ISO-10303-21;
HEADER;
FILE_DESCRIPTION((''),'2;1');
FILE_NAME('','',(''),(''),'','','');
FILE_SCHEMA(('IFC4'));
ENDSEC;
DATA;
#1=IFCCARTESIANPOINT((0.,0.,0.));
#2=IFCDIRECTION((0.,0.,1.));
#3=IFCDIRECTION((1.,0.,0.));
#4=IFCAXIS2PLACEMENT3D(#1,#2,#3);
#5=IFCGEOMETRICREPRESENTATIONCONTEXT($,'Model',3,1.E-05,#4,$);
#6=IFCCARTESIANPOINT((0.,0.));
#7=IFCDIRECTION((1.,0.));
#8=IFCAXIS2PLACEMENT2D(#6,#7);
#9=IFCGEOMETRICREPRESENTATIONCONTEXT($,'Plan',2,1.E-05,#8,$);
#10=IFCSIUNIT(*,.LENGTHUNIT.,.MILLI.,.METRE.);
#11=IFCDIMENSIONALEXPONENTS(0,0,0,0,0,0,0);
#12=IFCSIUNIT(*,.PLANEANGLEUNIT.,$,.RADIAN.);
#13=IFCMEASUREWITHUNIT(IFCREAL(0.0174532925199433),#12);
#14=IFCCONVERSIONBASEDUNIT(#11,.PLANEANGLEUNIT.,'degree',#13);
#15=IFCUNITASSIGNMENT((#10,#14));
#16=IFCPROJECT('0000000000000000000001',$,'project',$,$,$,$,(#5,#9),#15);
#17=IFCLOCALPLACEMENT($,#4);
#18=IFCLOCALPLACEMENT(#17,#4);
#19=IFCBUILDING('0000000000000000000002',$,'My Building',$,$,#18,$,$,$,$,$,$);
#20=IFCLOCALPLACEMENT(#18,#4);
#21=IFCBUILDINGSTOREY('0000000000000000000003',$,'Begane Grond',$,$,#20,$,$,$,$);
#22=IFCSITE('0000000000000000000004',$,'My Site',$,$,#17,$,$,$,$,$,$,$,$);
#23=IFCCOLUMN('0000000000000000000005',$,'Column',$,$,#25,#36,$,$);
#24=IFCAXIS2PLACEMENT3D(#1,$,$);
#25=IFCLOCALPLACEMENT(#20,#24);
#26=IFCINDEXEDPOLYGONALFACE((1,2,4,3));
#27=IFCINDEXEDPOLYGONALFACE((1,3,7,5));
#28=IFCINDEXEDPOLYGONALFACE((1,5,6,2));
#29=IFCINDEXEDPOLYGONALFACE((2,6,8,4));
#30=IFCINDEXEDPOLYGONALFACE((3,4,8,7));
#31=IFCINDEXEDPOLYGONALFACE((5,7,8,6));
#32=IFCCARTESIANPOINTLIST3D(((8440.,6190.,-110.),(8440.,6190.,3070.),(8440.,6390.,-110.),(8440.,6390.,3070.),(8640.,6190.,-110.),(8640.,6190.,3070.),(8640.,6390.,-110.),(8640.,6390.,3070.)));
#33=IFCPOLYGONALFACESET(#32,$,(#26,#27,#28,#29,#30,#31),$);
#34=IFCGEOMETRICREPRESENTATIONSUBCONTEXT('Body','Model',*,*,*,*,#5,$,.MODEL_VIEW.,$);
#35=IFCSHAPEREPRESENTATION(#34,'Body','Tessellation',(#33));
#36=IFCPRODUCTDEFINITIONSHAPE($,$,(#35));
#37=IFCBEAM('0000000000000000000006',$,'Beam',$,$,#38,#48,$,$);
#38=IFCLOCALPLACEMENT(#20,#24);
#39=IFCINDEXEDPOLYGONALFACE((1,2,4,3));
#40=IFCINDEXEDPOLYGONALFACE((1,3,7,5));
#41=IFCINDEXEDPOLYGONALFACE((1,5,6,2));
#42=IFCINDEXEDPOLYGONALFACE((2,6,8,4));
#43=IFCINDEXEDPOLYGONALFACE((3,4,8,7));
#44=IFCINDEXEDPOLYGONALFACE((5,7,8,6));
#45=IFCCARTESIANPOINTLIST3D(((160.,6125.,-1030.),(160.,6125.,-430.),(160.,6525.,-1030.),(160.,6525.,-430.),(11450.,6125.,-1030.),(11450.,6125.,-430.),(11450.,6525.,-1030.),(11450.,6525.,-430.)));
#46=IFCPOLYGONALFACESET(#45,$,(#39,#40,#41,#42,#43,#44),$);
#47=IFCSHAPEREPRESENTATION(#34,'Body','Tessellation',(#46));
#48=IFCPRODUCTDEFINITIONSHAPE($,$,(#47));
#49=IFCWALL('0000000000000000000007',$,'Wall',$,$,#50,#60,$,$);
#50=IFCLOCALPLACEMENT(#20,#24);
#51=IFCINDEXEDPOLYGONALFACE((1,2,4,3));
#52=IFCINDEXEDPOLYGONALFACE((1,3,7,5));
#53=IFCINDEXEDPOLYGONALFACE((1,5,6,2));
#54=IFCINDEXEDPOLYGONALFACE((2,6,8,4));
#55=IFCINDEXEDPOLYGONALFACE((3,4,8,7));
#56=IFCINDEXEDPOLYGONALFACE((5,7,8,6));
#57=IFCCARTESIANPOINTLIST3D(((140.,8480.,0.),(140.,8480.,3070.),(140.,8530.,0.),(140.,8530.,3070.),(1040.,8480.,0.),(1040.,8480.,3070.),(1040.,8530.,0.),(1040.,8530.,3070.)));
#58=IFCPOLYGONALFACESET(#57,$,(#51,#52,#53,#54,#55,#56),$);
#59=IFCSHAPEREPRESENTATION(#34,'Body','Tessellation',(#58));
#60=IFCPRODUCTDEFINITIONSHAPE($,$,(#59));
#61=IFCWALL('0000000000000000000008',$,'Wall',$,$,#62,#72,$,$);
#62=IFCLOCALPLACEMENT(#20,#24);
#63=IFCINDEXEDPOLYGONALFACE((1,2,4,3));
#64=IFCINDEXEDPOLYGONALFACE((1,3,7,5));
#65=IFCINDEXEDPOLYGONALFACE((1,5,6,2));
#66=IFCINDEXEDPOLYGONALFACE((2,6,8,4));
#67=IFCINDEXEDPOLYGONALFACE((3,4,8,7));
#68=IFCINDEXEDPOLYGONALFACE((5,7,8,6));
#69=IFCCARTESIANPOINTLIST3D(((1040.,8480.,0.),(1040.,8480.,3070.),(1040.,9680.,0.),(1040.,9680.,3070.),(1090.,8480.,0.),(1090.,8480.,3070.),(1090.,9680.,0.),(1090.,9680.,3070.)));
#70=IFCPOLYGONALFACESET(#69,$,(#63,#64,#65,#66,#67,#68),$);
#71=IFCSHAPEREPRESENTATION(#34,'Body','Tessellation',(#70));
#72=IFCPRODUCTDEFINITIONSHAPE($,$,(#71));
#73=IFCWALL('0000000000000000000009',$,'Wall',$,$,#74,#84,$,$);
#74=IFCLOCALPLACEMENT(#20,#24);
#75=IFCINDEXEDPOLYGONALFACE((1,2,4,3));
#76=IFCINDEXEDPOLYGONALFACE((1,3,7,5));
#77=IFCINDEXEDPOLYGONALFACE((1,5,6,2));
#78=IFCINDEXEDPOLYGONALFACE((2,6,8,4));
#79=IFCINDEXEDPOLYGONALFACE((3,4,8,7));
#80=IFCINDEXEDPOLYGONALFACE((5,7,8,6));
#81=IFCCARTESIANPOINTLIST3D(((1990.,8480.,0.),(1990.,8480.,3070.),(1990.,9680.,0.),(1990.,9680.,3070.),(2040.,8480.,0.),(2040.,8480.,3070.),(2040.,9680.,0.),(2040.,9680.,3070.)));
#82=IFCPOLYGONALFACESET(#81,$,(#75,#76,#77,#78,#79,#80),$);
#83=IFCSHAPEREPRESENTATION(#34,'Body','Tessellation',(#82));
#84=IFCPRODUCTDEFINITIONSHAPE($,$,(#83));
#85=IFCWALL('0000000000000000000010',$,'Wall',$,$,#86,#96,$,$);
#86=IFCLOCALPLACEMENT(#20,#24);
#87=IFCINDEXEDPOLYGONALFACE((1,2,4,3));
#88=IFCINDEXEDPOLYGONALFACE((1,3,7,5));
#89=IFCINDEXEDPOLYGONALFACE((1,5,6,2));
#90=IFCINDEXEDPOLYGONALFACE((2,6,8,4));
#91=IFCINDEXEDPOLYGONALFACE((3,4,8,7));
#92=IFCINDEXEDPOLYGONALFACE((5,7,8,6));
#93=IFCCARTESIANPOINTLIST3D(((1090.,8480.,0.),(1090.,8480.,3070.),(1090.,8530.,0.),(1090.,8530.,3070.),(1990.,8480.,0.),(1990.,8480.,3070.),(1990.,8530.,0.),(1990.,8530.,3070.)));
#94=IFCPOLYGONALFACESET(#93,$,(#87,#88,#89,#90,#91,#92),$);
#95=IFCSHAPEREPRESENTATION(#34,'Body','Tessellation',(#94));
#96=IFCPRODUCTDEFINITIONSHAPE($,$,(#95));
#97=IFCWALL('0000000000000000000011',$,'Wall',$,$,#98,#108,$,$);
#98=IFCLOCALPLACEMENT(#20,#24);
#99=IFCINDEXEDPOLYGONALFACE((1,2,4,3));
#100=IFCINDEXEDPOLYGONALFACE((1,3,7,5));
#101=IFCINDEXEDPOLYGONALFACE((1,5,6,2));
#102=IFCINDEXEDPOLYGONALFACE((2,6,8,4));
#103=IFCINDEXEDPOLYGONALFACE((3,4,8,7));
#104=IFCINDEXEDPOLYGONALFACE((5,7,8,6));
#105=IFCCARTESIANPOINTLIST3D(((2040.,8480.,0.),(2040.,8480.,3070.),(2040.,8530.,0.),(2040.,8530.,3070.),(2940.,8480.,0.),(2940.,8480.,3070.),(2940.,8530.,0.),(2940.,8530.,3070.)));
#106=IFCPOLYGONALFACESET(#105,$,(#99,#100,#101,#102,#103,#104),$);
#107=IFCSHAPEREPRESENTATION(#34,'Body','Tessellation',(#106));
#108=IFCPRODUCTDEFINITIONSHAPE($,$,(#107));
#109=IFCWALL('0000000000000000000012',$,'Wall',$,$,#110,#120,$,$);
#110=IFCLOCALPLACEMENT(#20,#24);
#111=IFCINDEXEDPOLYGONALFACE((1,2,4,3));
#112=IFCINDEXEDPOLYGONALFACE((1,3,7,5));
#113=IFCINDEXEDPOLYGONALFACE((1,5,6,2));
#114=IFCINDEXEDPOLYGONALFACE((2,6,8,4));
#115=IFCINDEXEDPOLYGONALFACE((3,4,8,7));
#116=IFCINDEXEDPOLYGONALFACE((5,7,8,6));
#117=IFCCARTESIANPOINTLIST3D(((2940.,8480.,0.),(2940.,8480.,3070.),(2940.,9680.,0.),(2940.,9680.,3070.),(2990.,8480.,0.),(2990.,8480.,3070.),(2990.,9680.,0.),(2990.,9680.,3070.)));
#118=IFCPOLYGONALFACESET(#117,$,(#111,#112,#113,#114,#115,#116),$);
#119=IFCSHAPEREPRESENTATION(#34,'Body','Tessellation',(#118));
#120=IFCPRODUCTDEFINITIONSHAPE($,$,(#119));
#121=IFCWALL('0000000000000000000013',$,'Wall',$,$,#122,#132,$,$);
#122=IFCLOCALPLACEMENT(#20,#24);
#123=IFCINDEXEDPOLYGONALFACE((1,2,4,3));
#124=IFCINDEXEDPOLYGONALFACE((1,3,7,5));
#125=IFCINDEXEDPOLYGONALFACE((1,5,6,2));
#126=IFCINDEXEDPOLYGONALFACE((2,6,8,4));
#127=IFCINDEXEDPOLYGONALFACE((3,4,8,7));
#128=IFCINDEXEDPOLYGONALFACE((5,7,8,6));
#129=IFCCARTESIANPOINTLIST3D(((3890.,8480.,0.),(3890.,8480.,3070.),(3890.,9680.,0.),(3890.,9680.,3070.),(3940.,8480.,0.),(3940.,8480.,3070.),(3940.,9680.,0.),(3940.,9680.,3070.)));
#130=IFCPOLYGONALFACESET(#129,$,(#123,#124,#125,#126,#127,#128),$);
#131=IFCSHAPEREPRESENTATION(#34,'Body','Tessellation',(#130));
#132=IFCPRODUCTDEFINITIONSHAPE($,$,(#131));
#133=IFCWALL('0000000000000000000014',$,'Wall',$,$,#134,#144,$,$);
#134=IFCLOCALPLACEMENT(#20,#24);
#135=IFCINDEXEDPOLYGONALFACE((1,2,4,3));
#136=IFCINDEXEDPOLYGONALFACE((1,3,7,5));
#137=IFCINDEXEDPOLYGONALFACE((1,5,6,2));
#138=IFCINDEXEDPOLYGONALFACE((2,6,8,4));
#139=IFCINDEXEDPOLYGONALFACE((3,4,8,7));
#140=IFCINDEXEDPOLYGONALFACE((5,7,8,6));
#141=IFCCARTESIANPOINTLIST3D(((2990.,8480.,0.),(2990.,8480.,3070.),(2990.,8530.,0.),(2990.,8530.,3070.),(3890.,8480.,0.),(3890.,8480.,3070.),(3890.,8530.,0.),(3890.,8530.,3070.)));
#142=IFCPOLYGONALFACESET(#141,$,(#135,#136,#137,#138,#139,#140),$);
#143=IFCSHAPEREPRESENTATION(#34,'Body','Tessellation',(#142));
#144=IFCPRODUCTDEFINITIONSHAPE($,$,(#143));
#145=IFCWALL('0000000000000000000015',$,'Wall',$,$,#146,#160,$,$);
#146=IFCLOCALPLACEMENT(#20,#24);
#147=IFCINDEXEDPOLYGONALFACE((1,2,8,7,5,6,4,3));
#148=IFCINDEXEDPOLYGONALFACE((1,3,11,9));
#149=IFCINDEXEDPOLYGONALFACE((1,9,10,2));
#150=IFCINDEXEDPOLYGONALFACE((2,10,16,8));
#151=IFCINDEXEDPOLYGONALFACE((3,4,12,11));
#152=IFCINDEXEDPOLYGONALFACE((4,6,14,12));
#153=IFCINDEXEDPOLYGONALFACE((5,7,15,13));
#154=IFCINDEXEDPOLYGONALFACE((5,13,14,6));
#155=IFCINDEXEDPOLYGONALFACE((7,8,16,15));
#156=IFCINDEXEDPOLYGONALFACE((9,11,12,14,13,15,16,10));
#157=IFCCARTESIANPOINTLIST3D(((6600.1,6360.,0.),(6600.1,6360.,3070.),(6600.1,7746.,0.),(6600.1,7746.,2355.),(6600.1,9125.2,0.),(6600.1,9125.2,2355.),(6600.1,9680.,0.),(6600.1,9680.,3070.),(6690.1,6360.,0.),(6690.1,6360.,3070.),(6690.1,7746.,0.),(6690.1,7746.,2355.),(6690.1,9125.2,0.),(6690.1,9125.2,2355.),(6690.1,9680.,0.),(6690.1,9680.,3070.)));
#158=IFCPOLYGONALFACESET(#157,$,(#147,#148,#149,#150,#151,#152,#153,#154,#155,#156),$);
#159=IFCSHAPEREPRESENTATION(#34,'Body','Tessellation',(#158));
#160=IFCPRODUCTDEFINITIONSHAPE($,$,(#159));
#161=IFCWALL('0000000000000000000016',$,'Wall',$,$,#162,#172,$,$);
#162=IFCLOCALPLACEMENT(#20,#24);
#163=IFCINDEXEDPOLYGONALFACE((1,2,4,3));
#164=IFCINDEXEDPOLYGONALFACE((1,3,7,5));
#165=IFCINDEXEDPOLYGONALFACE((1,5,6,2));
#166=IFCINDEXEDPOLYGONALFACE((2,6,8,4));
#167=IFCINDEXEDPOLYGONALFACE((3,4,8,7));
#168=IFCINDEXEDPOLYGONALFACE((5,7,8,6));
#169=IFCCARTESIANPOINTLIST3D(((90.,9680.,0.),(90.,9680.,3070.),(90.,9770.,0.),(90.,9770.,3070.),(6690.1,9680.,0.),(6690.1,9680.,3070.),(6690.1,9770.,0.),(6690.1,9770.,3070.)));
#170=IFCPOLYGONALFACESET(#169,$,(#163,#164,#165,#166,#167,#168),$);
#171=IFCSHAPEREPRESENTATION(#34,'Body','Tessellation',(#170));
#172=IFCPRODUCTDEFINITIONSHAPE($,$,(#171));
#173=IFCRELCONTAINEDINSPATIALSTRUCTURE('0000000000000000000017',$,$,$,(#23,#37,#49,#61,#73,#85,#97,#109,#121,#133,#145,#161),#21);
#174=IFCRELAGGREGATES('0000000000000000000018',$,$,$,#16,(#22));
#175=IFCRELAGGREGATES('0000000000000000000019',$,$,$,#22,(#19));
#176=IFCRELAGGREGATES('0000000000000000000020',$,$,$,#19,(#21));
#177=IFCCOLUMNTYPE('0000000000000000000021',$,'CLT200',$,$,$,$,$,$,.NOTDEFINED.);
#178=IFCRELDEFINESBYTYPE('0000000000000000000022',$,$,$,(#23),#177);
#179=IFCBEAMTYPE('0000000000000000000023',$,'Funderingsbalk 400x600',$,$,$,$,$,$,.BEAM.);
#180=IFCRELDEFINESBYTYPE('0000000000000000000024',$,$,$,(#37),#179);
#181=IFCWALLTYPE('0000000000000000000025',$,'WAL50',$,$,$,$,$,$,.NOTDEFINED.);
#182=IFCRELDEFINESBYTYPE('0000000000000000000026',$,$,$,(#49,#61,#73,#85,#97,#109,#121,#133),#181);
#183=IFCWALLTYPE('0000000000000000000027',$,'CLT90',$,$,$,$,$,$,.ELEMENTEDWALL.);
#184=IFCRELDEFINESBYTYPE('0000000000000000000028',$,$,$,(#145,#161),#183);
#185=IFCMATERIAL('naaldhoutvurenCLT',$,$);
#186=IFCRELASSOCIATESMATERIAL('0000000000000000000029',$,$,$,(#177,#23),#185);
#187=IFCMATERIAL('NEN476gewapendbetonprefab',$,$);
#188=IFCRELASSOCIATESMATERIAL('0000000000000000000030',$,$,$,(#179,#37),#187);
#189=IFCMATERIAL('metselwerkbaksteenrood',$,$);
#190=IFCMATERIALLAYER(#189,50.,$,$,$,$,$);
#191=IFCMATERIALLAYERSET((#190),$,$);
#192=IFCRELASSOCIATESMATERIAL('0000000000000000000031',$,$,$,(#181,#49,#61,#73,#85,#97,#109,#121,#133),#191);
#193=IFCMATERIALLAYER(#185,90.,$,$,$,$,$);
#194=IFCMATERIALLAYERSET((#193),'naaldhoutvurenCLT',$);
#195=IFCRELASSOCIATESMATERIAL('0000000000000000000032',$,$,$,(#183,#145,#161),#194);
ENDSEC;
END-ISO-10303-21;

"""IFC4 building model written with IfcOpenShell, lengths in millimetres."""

from ifc_helpers import new_model, entity, si_unit, converted_unit, frame, origin_with_axes, origin_2d_with_axis, place, context, subcontext, project, spatial, line, indexed_curve, rectangle, outline, extrude, clip, halfspace, source, transform, mapped, material, layer, layer_set, layer_usage, material_profile, profile_set, profile_usage, type_object, element, save


model = new_model("IFC4")

# Units and contexts
model_context = context("Model", 3, precision=1e-05, world=origin_with_axes())
plan_context = context("Plan", 2, precision=1e-05, world=origin_2d_with_axis())
body_context = subcontext(model_context, "Body", "Model", "MODEL_VIEW")
ifc_project = project(units=[si_unit("LENGTHUNIT", "METRE", prefix="MILLI"), converted_unit("PLANEANGLEUNIT", "degree", entity("IfcReal", 0.0174532925199433), si_unit("PLANEANGLEUNIT", "RADIAN"), dimensions=[0, 0, 0, 0, 0, 0, 0])], contexts=[model_context, plan_context])

# Site, building, storey
site_placement = place(None, origin_with_axes())
site = spatial("IfcSite", under=ifc_project, at=site_placement, Name="My Site")
building_placement = place(site_placement, origin_with_axes())
building = spatial("IfcBuilding", under=site, at=building_placement, Name="My Building")
storey_placement = place(building_placement, origin_with_axes())
storey = spatial("IfcBuildingStorey", under=building, at=storey_placement, Name="Begane Grond")

# Column
ifc_material_1 = material(Name="naaldhoutvurenCLT")
ifc_material_profile_1 = material_profile(ifc_material_1, rectangle(XDim=200.0, YDim=200.0))
ifc_profile_set_1 = profile_set([ifc_material_profile_1], Name="naaldhoutvurenCLT")
ifc_profile_usage_1 = profile_usage(ifc_profile_set_1, cardinal=5)
column_type = type_object("IfcColumnType", Name="CLT200", PredefinedType="NOTDEFINED", material=ifc_profile_set_1)
column_placement = place(storey_placement, frame((8540.0, 6290.0, -110.0), z_axis=(0.0, 0.0, 1.0), x_axis=(1.0, 0.0, 0.0)))
element("IfcColumn", 1, at=column_placement, inside=storey, type_object=column_type, material=ifc_profile_usage_1, Name="Column", context=body_context, shape_type="SweptSolid", body=[
    extrude(rectangle(XDim=200.0, YDim=200.0), origin_with_axes(), (0.0, 0.0, 1.0), 3180.0),
])

# Beam
ifc_material_2 = material(Name="NEN476gewapendbetonprefab")
ifc_material_profile_2 = material_profile(ifc_material_2, rectangle(XDim=400.0, YDim=600.0))
ifc_profile_set_2 = profile_set([ifc_material_profile_2], Name="gewapendbetonprefab")
ifc_profile_usage_2 = profile_usage(ifc_profile_set_2, cardinal=5)
beam_type = type_object("IfcBeamType", Name="Funderingsbalk 400x600", PredefinedType="BEAM", material=ifc_profile_set_2)
beam_placement = place(storey_placement, frame((11450.0, 6325.0, -730.0), z_axis=(-1.0, 0.0, 0.0), x_axis=(0.0, -1.0, 0.0)))
element("IfcBeam", 2, at=beam_placement, inside=storey, type_object=beam_type, material=ifc_profile_usage_2, Name="Beam", context=body_context, shape_type="SweptSolid", body=[
    extrude(rectangle(XDim=400.0, YDim=600.0), origin_with_axes(), (0.0, 0.0, 1.0), 11290.0),
])

# Walls
ifc_material_3 = material(Name="metselwerkbaksteenrood")
ifc_layer_1 = layer(ifc_material_3, 50.0)
ifc_layer_set_1 = layer_set([ifc_layer_1])
ifc_layer_usage_1 = layer_usage(ifc_layer_set_1, "AXIS2", "POSITIVE", 0.0)
wall_type_1 = type_object("IfcWallType", Name="WAL50", PredefinedType="NOTDEFINED", material=ifc_layer_set_1)
wall_1_placement = place(storey_placement, frame((140.0, 8480.0, 0.0), z_axis=(0.0, 0.0, 1.0), x_axis=(1.0, 0.0, 0.0)))
element("IfcWall", 3, at=wall_1_placement, inside=storey, type_object=wall_type_1, material=ifc_layer_usage_1, Name="Wall", context=body_context, shape_type="Clipping", body=[
    clip(extrude(outline(indexed_curve([(0.0, 0.0), (0.0, 50.0), (900.0, 50.0), (900.0, 0.0), (0.0, 0.0)], self_intersect=False)), origin_with_axes(), (0.0, 0.0, 1.0), 3070.0), halfspace(frame((0.0, 0.0, 3070.0), z_axis=(0.0, 0.0, 1.0), x_axis=(-1.0, 0.0, 0.0)), False)),
])
ifc_layer_usage_2 = layer_usage(ifc_layer_set_1, "AXIS2", "POSITIVE", 0.0)
wall_2_placement = place(storey_placement, frame((1040.0, 9680.0, 0.0), z_axis=(0.0, 0.0, 1.0), x_axis=(0.0, -1.0, 0.0)))
element("IfcWall", 4, at=wall_2_placement, inside=storey, type_object=wall_type_1, material=ifc_layer_usage_2, Name="Wall", context=body_context, shape_type="Clipping", body=[
    clip(extrude(outline(indexed_curve([(0.0, 0.0), (0.0, 50.0), (1200.0, 50.0), (1200.0, 0.0), (0.0, 0.0)], self_intersect=False)), origin_with_axes(), (0.0, 0.0, 1.0), 3070.0), halfspace(frame((0.0, 0.0, 3070.0), z_axis=(0.0, 0.0, 1.0), x_axis=(-1.0, 0.0, 0.0)), False)),
])
ifc_layer_usage_3 = layer_usage(ifc_layer_set_1, "AXIS2", "POSITIVE", 0.0)
wall_3_placement = place(storey_placement, frame((1990.0, 9680.0, 0.0), z_axis=(0.0, 0.0, 1.0), x_axis=(0.0, -1.0, 0.0)))
element("IfcWall", 5, at=wall_3_placement, inside=storey, type_object=wall_type_1, material=ifc_layer_usage_3, Name="Wall", context=body_context, shape_type="Clipping", body=[
    clip(extrude(outline(indexed_curve([(0.0, 0.0), (0.0, 50.0), (1200.0, 50.0), (1200.0, 0.0), (0.0, 0.0)], self_intersect=False)), origin_with_axes(), (0.0, 0.0, 1.0), 3070.0), halfspace(frame((0.0, 0.0, 3070.0), z_axis=(0.0, 0.0, 1.0), x_axis=(-1.0, 0.0, 0.0)), False)),
])
ifc_layer_usage_4 = layer_usage(ifc_layer_set_1, "AXIS2", "POSITIVE", 0.0)
wall_4_placement = place(storey_placement, frame((1090.0, 8480.0, 0.0), z_axis=(0.0, 0.0, 1.0), x_axis=(1.0, 0.0, 0.0)))
element("IfcWall", 6, at=wall_4_placement, inside=storey, type_object=wall_type_1, material=ifc_layer_usage_4, Name="Wall", context=body_context, shape_type="Clipping", body=[
    clip(extrude(outline(indexed_curve([(0.0, 0.0), (0.0, 50.0), (900.0, 50.0), (900.0, 0.0), (0.0, 0.0)], self_intersect=False)), origin_with_axes(), (0.0, 0.0, 1.0), 3070.0), halfspace(frame((0.0, 0.0, 3070.0), z_axis=(0.0, 0.0, 1.0), x_axis=(-1.0, 0.0, 0.0)), False)),
])
ifc_layer_usage_5 = layer_usage(ifc_layer_set_1, "AXIS2", "POSITIVE", 0.0)
wall_5_placement = place(storey_placement, frame((2040.0, 8480.0, 0.0), z_axis=(0.0, 0.0, 1.0), x_axis=(1.0, 0.0, 0.0)))
element("IfcWall", 7, at=wall_5_placement, inside=storey, type_object=wall_type_1, material=ifc_layer_usage_5, Name="Wall", context=body_context, shape_type="Clipping", body=[
    clip(extrude(outline(indexed_curve([(0.0, 0.0), (0.0, 50.0), (900.0, 50.0), (900.0, 0.0), (0.0, 0.0)], self_intersect=False)), origin_with_axes(), (0.0, 0.0, 1.0), 3070.0), halfspace(frame((0.0, 0.0, 3070.0), z_axis=(0.0, 0.0, 1.0), x_axis=(-1.0, 0.0, 0.0)), False)),
])
ifc_layer_usage_6 = layer_usage(ifc_layer_set_1, "AXIS2", "POSITIVE", 0.0)
wall_6_placement = place(storey_placement, frame((2940.0, 9680.0, 0.0), z_axis=(0.0, 0.0, 1.0), x_axis=(0.0, -1.0, 0.0)))
element("IfcWall", 8, at=wall_6_placement, inside=storey, type_object=wall_type_1, material=ifc_layer_usage_6, Name="Wall", context=body_context, shape_type="Clipping", body=[
    clip(extrude(outline(indexed_curve([(0.0, 0.0), (0.0, 50.0), (1200.0, 50.0), (1200.0, 0.0), (0.0, 0.0)], self_intersect=False)), origin_with_axes(), (0.0, 0.0, 1.0), 3070.0), halfspace(frame((0.0, 0.0, 3070.0), z_axis=(0.0, 0.0, 1.0), x_axis=(-1.0, 0.0, 0.0)), False)),
])
ifc_layer_usage_7 = layer_usage(ifc_layer_set_1, "AXIS2", "POSITIVE", 0.0)
wall_7_placement = place(storey_placement, frame((3890.0, 9680.0, 0.0), z_axis=(0.0, 0.0, 1.0), x_axis=(0.0, -1.0, 0.0)))
element("IfcWall", 9, at=wall_7_placement, inside=storey, type_object=wall_type_1, material=ifc_layer_usage_7, Name="Wall", context=body_context, shape_type="Clipping", body=[
    clip(extrude(outline(indexed_curve([(0.0, 0.0), (0.0, 50.0), (1200.0, 50.0), (1200.0, 0.0), (0.0, 0.0)], self_intersect=False)), origin_with_axes(), (0.0, 0.0, 1.0), 3070.0), halfspace(frame((0.0, 0.0, 3070.0), z_axis=(0.0, 0.0, 1.0), x_axis=(-1.0, 0.0, 0.0)), False)),
])
ifc_layer_usage_8 = layer_usage(ifc_layer_set_1, "AXIS2", "POSITIVE", 0.0)
wall_8_placement = place(storey_placement, frame((2990.0, 8480.0, 0.0), z_axis=(0.0, 0.0, 1.0), x_axis=(1.0, 0.0, 0.0)))
element("IfcWall", 10, at=wall_8_placement, inside=storey, type_object=wall_type_1, material=ifc_layer_usage_8, Name="Wall", context=body_context, shape_type="Clipping", body=[
    clip(extrude(outline(indexed_curve([(0.0, 0.0), (0.0, 50.0), (900.0, 50.0), (900.0, 0.0), (0.0, 0.0)], self_intersect=False)), origin_with_axes(), (0.0, 0.0, 1.0), 3070.0), halfspace(frame((0.0, 0.0, 3070.0), z_axis=(0.0, 0.0, 1.0), x_axis=(-1.0, 0.0, 0.0)), False)),
])

# Wall, opening
ifc_layer_2 = layer(ifc_material_1, 90.0)
ifc_layer_set_2 = layer_set([ifc_layer_2], Name="naaldhoutvurenCLT")
ifc_layer_usage_9 = layer_usage(ifc_layer_set_2, "AXIS2", "POSITIVE", 0.0)
wall_type_2 = type_object("IfcWallType", Name="CLT90", PredefinedType="ELEMENTEDWALL", material=ifc_layer_set_2)
wall_9_placement = place(storey_placement, frame((6690.1, 6360.0, 0.0), z_axis=(0.0, 0.0, 1.0), x_axis=(0.0, 1.0, 0.0)))
wall_9 = element("IfcWall", 11, at=wall_9_placement, inside=storey, type_object=wall_type_2, material=ifc_layer_usage_9, Name="Wall", context=body_context, shape_type="SweptSolid", body=[
    extrude(outline(indexed_curve([(0.0, 0.0), (0.0, 90.0), (3320.0, 90.0), (3320.0, 0.0), (0.0, 0.0)], self_intersect=False)), origin_with_axes(), (0.0, 0.0, 1.0), 3070.0),
])
shared_shape_1 = source(origin_with_axes(), body_context, "Body", "SweptSolid", [
    extrude(outline(indexed_curve([(0.0, 0.0), (1379.2, 0.0), (1379.2, 2355.0), (0.0, 2355.0)], segments=[line(1, 2, 3, 4, 1)])), frame((0.0, -600.0, 0.0), z_axis=(0.0, -1.0, 0.0), x_axis=(1.0, 0.0, 0.0)), (0.0, 0.0, -1.0), 1200.0),
])
opening_1_placement = place(wall_9_placement, frame((1386.0, -11.0, 0.0), z_axis=(0.0, 0.0, 1.0), x_axis=(1.0, 0.0, 0.0)))
element("IfcOpeningElement", 12, at=opening_1_placement, cuts=wall_9, PredefinedType="OPENING", context=body_context, shape_type="MappedRepresentation", body=[
    mapped(shared_shape_1, transform((0.0, 0.0, 0.0), x_axis=(1.0, 0.0, 0.0), y_axis=(0.0, 1.0, 0.0), z_axis=(0.0, 0.0, 1.0), scale=1.0)),
])

# Wall
ifc_layer_usage_10 = layer_usage(ifc_layer_set_2, "AXIS2", "POSITIVE", 0.0)
wall_10_placement = place(storey_placement, frame((6690.1, 9770.0, 0.0), z_axis=(0.0, 0.0, 1.0), x_axis=(-1.0, 0.0, 0.0)))
element("IfcWall", 13, at=wall_10_placement, inside=storey, type_object=wall_type_2, material=ifc_layer_usage_10, Name="Wall", context=body_context, shape_type="SweptSolid", body=[
    extrude(outline(indexed_curve([(0.0, 0.0), (0.0, 90.0), (6600.1, 90.0), (6600.1, 0.0), (0.0, 0.0)], self_intersect=False)), origin_with_axes(), (0.0, 0.0, 1.0), 3070.0),
])

save(model, "model.ifc")
